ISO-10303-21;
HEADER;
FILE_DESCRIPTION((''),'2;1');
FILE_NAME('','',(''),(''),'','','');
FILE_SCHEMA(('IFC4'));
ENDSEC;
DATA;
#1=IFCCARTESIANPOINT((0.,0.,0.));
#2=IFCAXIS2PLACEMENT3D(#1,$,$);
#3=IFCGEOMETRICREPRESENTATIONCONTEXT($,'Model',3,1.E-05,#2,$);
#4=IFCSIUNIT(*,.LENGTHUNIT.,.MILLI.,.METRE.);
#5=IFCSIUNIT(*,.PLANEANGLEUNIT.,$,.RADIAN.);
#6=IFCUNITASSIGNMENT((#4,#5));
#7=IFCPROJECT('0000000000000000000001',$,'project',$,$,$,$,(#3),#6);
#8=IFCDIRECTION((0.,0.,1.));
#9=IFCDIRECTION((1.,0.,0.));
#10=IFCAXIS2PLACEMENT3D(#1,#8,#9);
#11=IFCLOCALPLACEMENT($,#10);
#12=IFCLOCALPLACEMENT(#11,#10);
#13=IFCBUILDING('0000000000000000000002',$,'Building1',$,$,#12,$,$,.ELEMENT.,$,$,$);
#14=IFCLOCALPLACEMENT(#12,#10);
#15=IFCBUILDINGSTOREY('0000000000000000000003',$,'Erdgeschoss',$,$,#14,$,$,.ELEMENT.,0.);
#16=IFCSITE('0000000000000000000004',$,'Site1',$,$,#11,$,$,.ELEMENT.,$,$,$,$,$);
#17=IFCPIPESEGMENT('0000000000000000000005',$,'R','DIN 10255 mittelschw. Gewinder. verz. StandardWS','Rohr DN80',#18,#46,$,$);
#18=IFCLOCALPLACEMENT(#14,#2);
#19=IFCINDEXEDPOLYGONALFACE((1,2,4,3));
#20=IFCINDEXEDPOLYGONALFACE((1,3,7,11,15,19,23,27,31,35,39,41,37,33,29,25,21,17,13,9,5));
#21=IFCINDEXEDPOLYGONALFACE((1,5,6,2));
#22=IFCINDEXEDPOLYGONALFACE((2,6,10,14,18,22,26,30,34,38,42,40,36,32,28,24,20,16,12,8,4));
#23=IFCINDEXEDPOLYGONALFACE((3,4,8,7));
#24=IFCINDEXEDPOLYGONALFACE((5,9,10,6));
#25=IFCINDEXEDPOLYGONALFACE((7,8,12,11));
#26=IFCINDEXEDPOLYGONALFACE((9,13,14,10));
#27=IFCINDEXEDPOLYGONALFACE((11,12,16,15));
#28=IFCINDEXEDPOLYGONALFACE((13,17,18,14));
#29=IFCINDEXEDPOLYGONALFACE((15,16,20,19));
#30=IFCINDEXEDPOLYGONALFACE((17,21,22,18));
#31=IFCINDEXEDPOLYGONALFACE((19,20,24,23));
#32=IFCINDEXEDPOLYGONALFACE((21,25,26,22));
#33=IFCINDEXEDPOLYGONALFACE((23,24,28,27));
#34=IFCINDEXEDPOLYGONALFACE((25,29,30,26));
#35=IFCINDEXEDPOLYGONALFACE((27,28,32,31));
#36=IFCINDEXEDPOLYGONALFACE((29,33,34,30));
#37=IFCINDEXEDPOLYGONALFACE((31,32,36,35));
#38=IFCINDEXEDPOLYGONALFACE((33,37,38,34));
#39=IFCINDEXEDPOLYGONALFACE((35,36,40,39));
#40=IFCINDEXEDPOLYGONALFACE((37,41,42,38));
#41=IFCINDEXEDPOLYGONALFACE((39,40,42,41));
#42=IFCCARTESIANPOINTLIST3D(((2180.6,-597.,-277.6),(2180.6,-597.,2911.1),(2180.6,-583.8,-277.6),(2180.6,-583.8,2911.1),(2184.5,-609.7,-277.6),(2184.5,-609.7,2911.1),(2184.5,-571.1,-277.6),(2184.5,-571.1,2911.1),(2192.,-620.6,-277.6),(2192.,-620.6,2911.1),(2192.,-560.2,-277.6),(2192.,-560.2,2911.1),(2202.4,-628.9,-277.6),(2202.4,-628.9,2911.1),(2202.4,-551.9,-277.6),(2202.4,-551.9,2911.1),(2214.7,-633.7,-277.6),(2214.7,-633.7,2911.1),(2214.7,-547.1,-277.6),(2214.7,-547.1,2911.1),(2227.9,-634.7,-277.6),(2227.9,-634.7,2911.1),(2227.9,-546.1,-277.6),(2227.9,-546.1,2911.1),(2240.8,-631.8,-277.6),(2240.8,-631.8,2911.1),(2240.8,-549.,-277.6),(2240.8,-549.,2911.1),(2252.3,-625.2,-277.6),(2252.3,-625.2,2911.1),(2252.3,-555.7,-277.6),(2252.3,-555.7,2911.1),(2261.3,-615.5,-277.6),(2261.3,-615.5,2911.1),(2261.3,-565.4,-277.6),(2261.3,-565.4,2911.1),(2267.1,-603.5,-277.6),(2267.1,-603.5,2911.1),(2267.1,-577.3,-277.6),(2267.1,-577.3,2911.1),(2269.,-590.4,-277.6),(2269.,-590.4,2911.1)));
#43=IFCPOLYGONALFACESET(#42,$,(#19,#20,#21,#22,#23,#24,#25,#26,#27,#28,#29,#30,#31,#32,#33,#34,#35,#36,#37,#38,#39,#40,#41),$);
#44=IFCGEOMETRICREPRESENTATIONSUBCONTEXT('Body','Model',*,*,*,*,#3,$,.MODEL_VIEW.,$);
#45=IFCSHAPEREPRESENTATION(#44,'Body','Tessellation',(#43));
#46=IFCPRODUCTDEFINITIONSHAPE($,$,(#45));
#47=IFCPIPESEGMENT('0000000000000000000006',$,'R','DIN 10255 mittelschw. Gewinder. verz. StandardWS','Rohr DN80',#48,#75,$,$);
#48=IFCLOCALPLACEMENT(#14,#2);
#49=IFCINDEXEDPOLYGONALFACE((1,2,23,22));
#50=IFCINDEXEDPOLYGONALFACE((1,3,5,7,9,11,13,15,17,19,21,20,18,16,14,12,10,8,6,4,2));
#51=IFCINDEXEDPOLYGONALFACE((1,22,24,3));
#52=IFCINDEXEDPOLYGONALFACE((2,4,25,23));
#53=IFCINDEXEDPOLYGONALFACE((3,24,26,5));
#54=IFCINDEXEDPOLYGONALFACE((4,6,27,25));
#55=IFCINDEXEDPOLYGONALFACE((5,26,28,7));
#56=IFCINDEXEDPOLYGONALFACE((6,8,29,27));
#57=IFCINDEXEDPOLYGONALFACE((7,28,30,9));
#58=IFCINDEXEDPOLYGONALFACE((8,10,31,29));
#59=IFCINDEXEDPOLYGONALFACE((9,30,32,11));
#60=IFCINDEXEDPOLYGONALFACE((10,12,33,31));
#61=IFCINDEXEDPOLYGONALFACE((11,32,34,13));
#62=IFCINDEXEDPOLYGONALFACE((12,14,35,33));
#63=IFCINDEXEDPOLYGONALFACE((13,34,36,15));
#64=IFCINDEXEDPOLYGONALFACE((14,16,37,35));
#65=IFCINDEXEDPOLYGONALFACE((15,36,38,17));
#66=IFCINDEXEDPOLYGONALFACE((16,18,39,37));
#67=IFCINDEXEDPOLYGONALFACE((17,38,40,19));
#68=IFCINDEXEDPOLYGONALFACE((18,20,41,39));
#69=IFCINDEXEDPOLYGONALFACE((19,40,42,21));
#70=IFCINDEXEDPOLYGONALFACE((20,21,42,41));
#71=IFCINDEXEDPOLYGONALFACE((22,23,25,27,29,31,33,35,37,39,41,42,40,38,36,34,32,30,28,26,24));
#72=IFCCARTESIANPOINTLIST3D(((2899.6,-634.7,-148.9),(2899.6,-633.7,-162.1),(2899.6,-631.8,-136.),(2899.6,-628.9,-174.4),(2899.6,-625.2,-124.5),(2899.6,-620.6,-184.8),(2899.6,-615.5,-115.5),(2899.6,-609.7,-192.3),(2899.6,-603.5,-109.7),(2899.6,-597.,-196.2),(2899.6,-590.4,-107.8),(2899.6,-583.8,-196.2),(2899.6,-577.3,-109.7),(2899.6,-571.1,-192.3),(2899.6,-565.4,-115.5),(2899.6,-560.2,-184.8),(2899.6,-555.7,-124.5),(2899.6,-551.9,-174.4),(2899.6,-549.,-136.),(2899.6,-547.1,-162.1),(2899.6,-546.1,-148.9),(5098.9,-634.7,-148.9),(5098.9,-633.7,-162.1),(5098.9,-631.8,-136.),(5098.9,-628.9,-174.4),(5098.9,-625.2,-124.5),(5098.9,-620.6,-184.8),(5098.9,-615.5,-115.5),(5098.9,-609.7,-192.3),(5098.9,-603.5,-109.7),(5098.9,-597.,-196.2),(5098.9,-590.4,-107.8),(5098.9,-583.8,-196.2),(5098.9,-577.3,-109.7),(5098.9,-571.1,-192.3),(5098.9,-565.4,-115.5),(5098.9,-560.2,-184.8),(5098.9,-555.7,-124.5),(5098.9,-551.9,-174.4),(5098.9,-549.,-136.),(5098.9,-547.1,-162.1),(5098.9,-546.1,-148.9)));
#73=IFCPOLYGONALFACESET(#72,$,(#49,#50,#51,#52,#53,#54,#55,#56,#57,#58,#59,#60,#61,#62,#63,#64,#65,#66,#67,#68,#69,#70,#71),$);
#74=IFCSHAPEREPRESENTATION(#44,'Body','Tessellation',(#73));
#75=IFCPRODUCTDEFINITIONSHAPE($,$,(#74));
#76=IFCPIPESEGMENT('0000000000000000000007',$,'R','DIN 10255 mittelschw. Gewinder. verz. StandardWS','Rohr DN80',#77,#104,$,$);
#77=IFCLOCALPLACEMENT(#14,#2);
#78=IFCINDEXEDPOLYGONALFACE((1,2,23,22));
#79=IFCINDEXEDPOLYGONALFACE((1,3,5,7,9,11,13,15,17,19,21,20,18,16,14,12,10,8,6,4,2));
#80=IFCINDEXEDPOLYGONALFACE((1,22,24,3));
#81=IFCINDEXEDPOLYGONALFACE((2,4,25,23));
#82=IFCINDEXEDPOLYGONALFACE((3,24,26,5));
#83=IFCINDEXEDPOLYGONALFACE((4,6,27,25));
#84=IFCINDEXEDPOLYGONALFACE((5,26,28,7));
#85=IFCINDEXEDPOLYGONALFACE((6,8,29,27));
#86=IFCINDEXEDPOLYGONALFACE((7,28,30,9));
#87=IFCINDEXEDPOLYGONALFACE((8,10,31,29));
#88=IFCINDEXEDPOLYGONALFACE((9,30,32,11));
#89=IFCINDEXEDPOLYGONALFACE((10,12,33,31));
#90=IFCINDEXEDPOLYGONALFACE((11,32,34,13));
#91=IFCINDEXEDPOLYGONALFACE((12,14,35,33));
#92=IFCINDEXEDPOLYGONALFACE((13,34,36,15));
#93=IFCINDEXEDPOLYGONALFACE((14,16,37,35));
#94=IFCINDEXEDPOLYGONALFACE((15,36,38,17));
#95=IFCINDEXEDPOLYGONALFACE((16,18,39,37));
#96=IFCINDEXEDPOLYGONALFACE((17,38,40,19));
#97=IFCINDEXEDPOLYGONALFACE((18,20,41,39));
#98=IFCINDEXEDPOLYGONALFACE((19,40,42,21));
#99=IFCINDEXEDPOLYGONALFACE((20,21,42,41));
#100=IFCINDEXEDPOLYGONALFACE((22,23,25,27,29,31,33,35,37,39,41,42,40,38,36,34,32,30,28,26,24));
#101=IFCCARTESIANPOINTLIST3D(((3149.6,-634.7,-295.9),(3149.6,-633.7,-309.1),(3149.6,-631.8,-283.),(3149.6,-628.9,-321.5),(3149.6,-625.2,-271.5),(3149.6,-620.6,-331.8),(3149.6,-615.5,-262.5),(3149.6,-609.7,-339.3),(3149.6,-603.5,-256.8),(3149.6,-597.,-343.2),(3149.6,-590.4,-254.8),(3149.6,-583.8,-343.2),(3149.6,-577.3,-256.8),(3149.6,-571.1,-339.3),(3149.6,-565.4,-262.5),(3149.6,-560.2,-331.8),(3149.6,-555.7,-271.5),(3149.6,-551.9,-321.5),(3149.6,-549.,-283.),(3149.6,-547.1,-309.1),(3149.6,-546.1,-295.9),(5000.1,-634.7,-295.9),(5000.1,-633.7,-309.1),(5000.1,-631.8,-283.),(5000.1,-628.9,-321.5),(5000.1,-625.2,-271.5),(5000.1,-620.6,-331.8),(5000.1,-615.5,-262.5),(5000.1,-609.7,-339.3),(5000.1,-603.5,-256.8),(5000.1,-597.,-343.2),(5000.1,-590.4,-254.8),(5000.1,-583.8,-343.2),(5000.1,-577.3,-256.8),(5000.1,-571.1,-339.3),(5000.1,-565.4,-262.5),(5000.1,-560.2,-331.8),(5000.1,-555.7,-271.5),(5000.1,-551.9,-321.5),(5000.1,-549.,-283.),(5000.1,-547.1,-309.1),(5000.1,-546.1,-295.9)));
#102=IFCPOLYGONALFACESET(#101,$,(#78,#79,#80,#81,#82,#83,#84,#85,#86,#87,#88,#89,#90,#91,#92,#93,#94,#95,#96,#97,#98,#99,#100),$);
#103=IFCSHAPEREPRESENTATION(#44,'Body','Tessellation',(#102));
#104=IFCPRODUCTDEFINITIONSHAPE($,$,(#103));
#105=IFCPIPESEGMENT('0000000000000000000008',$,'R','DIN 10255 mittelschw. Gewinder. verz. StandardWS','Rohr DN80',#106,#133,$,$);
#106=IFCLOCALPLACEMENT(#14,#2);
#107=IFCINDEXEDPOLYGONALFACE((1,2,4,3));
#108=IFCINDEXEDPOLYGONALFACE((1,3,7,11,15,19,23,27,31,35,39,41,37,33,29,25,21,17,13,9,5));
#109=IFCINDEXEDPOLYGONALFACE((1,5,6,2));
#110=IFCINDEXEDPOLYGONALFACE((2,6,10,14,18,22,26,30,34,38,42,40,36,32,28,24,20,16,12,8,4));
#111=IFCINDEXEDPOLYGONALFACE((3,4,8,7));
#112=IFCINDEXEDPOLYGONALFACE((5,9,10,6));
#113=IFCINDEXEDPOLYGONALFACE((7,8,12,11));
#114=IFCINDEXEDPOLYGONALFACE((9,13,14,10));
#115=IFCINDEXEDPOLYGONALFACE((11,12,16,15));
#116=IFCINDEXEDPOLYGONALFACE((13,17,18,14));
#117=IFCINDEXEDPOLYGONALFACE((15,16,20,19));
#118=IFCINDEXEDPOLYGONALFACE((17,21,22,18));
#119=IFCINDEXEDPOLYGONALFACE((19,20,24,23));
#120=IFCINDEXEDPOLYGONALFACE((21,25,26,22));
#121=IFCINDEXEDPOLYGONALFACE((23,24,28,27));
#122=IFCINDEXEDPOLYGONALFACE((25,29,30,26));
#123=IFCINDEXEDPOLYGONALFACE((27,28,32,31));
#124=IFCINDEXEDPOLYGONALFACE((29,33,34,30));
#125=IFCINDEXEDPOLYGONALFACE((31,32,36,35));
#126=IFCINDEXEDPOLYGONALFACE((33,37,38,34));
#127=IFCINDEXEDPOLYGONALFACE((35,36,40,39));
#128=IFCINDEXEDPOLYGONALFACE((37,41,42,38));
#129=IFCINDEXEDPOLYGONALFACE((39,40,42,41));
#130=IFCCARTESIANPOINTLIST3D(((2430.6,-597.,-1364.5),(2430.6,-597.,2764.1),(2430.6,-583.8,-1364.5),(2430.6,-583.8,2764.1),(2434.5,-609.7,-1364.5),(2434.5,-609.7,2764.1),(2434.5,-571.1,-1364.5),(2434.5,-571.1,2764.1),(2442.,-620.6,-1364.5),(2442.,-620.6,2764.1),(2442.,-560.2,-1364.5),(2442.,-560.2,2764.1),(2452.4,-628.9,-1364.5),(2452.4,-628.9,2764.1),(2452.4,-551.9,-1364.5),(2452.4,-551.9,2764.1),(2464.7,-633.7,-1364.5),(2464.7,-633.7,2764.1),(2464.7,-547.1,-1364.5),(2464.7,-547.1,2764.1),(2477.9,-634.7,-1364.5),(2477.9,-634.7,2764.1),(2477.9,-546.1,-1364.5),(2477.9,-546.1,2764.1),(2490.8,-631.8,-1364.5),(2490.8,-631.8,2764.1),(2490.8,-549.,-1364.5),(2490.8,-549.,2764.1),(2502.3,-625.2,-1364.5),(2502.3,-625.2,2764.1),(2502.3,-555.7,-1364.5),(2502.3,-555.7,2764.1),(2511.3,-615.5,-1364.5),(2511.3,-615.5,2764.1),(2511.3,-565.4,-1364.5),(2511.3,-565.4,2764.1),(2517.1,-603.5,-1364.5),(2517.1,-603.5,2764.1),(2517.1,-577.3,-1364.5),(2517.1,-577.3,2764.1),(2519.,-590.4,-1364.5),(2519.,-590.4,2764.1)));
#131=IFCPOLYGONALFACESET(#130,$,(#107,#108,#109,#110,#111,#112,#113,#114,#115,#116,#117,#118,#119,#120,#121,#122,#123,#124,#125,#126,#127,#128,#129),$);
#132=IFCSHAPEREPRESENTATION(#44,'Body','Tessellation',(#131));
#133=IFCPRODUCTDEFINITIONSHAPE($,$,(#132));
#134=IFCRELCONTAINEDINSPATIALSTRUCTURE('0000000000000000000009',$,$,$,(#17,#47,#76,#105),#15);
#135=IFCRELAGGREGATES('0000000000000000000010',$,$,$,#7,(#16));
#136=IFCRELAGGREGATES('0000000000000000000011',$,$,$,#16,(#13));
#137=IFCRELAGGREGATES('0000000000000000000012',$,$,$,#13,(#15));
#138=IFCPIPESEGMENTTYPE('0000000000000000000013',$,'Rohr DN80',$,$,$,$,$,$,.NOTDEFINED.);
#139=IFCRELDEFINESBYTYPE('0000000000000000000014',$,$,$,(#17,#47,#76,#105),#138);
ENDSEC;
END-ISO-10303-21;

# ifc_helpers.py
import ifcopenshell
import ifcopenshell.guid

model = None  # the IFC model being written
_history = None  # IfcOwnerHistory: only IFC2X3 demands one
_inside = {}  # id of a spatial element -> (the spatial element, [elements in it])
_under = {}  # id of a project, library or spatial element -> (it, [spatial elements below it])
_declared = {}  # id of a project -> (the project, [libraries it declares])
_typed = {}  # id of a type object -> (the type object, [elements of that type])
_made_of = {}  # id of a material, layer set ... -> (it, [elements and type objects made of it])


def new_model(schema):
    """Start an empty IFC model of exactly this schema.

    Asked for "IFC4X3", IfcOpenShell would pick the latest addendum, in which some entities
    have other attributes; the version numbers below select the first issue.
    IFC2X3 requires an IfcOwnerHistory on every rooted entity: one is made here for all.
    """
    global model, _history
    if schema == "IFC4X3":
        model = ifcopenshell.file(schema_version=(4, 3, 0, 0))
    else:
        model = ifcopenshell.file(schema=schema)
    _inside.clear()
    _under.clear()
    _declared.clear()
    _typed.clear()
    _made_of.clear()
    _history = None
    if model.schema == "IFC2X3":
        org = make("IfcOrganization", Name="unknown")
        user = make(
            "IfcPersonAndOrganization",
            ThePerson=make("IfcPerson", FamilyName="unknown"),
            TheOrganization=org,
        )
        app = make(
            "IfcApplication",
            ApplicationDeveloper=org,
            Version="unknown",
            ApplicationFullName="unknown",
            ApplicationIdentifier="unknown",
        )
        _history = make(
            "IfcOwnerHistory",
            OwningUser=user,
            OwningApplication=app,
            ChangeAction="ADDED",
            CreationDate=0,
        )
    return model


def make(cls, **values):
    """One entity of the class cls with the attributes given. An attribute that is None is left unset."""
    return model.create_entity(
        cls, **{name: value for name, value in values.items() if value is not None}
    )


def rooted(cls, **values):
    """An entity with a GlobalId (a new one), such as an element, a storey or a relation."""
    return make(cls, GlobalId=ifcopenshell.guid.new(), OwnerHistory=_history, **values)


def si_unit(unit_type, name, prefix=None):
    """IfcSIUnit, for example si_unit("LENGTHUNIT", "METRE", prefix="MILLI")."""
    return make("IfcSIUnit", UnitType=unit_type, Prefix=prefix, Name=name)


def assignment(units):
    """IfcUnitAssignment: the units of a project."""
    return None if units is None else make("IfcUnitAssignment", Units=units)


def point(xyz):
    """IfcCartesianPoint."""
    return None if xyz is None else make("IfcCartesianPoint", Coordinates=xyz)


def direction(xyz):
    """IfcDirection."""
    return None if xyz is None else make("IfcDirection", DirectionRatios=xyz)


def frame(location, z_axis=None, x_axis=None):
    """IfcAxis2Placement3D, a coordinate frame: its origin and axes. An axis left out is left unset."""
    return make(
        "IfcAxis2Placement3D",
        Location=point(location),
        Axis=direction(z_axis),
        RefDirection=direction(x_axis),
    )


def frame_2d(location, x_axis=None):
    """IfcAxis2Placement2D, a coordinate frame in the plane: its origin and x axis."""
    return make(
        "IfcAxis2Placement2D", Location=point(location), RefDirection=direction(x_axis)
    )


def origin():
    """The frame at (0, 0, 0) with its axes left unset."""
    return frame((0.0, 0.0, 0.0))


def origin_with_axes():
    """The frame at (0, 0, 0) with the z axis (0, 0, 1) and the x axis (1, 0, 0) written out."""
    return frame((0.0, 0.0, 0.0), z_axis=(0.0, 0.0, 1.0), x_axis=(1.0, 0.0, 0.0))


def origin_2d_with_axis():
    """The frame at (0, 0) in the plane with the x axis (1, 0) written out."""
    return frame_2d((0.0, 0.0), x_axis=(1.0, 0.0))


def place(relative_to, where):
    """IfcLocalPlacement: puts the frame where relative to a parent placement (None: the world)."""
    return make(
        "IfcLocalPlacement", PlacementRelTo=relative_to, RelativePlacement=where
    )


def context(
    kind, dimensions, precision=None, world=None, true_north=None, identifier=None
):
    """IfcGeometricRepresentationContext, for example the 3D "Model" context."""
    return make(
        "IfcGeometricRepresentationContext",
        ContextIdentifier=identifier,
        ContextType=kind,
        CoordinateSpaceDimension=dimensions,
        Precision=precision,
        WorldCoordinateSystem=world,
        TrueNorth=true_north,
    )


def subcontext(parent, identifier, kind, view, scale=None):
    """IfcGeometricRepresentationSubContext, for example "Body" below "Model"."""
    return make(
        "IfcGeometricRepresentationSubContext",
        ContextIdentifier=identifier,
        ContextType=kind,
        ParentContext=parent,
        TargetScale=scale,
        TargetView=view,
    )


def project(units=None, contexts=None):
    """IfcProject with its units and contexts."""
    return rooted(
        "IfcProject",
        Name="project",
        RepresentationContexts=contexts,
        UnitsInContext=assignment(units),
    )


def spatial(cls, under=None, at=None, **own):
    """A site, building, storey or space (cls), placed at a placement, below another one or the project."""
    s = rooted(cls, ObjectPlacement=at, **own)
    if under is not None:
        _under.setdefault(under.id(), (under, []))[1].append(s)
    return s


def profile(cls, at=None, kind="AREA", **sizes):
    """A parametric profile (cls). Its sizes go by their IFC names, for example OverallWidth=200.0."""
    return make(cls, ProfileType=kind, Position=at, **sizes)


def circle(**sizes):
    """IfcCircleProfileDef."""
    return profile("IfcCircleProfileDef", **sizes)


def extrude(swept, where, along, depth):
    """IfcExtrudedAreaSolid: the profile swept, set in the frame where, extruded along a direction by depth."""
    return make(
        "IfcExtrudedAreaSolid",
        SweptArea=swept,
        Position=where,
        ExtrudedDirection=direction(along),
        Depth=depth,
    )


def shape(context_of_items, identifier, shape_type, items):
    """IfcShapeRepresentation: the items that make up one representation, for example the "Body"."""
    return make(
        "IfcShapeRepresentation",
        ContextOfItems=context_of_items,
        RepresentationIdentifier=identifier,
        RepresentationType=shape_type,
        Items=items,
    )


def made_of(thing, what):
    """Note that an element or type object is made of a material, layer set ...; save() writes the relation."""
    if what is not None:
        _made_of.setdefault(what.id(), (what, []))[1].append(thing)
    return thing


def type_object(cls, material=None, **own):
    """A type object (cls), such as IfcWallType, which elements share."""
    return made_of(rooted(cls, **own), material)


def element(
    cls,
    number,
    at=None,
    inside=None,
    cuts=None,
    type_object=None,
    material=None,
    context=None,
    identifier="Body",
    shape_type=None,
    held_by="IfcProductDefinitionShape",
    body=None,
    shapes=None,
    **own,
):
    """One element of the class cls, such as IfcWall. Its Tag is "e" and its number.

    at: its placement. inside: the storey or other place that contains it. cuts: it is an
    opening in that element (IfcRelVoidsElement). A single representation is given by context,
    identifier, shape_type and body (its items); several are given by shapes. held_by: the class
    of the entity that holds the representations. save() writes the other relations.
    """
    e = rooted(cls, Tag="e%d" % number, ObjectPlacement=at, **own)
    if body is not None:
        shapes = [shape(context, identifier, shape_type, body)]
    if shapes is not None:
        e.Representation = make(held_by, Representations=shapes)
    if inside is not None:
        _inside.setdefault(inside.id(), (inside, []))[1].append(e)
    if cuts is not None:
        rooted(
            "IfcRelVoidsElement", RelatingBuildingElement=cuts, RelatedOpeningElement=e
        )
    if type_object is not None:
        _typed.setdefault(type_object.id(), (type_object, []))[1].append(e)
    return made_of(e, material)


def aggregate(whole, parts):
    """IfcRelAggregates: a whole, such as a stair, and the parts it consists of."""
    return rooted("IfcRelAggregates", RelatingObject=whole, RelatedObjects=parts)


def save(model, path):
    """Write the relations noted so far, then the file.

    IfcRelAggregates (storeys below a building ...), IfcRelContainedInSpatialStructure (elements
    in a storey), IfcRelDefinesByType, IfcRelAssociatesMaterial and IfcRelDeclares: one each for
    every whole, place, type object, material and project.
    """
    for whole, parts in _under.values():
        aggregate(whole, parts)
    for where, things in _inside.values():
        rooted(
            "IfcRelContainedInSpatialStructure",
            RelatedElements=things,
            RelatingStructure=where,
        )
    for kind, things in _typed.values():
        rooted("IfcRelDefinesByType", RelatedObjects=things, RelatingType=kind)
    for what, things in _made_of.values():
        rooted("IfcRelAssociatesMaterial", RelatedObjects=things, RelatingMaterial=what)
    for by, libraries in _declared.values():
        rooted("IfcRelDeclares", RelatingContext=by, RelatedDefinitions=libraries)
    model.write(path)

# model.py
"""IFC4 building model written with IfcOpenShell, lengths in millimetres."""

from ifc_helpers import new_model, si_unit, frame, origin, origin_with_axes, origin_2d_with_axis, place, context, subcontext, project, spatial, circle, extrude, type_object, element, save


model = new_model("IFC4")

# Units and contexts
model_context = context("Model", 3, precision=1e-05, world=origin())
body_context = subcontext(model_context, "Body", "Model", "MODEL_VIEW")
ifc_project = project(units=[si_unit("LENGTHUNIT", "METRE", prefix="MILLI"), si_unit("PLANEANGLEUNIT", "RADIAN")], contexts=[model_context])

# Site, building, storey
site_placement = place(None, origin_with_axes())
site = spatial("IfcSite", under=ifc_project, at=site_placement, Name="Site1", CompositionType="ELEMENT")
building_placement = place(site_placement, origin_with_axes())
building = spatial("IfcBuilding", under=site, at=building_placement, Name="Building1", CompositionType="ELEMENT")
storey_placement = place(building_placement, origin_with_axes())
storey = spatial("IfcBuildingStorey", under=building, at=storey_placement, Name="Erdgeschoss", CompositionType="ELEMENT", Elevation=0.0)

# Pipe segments
pipe_segment_type_1 = type_object("IfcPipeSegmentType", Name="Rohr DN80", PredefinedType="NOTDEFINED")
pipe_segment_1_placement = place(storey_placement, frame((2224.6, -590.6, 1316.8), z_axis=(0.0, 0.0, 1.0), x_axis=(1.0, 0.0, 0.0)))
element("IfcPipeSegment", 1, at=pipe_segment_1_placement, inside=storey, type_object=pipe_segment_type_1, Name="R", Description="DIN 10255 mittelschw. Gewinder. verz. StandardWS", ObjectType="Rohr DN80", context=body_context, shape_type="SolidModel", body=[
    extrude(circle(Radius=44.5, at=origin_2d_with_axis()), frame((0.0, 0.1, -1594.4), z_axis=(0.0, 0.0, 1.0), x_axis=(1.0, 0.0, 0.0)), (0.0, 0.0, 1.0), 3188.8),
])
pipe_segment_2_placement = place(storey_placement, frame((3999.2, -590.3, -152.2), z_axis=(0.0, 0.0, 1.0), x_axis=(1.0, 0.0, 0.0)))
element("IfcPipeSegment", 2, at=pipe_segment_2_placement, inside=storey, type_object=pipe_segment_type_1, Name="R", Description="DIN 10255 mittelschw. Gewinder. verz. StandardWS", ObjectType="Rohr DN80", context=body_context, shape_type="SolidModel", body=[
    extrude(circle(Radius=44.5, at=origin_2d_with_axis()), frame((-1099.6, -0.2, 0.0), z_axis=(1.0, 0.0, 0.0), x_axis=(0.0, 0.0, 1.0)), (0.0, 0.0, 1.0), 2199.3),
])
pipe_segment_3_placement = place(storey_placement, frame((4074.8, -590.3, -299.2), z_axis=(0.0, 0.0, 1.0), x_axis=(1.0, 0.0, 0.0)))
element("IfcPipeSegment", 3, at=pipe_segment_3_placement, inside=storey, type_object=pipe_segment_type_1, Name="R", Description="DIN 10255 mittelschw. Gewinder. verz. StandardWS", ObjectType="Rohr DN80", context=body_context, shape_type="SolidModel", body=[
    extrude(circle(Radius=44.5, at=origin_2d_with_axis()), frame((-925.3, -0.2, 0.0), z_axis=(1.0, 0.0, 0.0), x_axis=(0.0, 0.0, 1.0)), (0.0, 0.0, 1.0), 1850.5),
])
pipe_segment_4_placement = place(storey_placement, frame((2474.6, -590.6, 699.8), z_axis=(0.0, 0.0, 1.0), x_axis=(1.0, 0.0, 0.0)))
element("IfcPipeSegment", 4, at=pipe_segment_4_placement, inside=storey, type_object=pipe_segment_type_1, Name="R", Description="DIN 10255 mittelschw. Gewinder. verz. StandardWS", ObjectType="Rohr DN80", context=body_context, shape_type="SolidModel", body=[
    extrude(circle(Radius=44.5, at=origin_2d_with_axis()), frame((0.0, 0.1, -2064.3), z_axis=(0.0, 0.0, 1.0), x_axis=(1.0, 0.0, 0.0)), (0.0, 0.0, 1.0), 4128.7),
])

save(model, "model.ifc")
